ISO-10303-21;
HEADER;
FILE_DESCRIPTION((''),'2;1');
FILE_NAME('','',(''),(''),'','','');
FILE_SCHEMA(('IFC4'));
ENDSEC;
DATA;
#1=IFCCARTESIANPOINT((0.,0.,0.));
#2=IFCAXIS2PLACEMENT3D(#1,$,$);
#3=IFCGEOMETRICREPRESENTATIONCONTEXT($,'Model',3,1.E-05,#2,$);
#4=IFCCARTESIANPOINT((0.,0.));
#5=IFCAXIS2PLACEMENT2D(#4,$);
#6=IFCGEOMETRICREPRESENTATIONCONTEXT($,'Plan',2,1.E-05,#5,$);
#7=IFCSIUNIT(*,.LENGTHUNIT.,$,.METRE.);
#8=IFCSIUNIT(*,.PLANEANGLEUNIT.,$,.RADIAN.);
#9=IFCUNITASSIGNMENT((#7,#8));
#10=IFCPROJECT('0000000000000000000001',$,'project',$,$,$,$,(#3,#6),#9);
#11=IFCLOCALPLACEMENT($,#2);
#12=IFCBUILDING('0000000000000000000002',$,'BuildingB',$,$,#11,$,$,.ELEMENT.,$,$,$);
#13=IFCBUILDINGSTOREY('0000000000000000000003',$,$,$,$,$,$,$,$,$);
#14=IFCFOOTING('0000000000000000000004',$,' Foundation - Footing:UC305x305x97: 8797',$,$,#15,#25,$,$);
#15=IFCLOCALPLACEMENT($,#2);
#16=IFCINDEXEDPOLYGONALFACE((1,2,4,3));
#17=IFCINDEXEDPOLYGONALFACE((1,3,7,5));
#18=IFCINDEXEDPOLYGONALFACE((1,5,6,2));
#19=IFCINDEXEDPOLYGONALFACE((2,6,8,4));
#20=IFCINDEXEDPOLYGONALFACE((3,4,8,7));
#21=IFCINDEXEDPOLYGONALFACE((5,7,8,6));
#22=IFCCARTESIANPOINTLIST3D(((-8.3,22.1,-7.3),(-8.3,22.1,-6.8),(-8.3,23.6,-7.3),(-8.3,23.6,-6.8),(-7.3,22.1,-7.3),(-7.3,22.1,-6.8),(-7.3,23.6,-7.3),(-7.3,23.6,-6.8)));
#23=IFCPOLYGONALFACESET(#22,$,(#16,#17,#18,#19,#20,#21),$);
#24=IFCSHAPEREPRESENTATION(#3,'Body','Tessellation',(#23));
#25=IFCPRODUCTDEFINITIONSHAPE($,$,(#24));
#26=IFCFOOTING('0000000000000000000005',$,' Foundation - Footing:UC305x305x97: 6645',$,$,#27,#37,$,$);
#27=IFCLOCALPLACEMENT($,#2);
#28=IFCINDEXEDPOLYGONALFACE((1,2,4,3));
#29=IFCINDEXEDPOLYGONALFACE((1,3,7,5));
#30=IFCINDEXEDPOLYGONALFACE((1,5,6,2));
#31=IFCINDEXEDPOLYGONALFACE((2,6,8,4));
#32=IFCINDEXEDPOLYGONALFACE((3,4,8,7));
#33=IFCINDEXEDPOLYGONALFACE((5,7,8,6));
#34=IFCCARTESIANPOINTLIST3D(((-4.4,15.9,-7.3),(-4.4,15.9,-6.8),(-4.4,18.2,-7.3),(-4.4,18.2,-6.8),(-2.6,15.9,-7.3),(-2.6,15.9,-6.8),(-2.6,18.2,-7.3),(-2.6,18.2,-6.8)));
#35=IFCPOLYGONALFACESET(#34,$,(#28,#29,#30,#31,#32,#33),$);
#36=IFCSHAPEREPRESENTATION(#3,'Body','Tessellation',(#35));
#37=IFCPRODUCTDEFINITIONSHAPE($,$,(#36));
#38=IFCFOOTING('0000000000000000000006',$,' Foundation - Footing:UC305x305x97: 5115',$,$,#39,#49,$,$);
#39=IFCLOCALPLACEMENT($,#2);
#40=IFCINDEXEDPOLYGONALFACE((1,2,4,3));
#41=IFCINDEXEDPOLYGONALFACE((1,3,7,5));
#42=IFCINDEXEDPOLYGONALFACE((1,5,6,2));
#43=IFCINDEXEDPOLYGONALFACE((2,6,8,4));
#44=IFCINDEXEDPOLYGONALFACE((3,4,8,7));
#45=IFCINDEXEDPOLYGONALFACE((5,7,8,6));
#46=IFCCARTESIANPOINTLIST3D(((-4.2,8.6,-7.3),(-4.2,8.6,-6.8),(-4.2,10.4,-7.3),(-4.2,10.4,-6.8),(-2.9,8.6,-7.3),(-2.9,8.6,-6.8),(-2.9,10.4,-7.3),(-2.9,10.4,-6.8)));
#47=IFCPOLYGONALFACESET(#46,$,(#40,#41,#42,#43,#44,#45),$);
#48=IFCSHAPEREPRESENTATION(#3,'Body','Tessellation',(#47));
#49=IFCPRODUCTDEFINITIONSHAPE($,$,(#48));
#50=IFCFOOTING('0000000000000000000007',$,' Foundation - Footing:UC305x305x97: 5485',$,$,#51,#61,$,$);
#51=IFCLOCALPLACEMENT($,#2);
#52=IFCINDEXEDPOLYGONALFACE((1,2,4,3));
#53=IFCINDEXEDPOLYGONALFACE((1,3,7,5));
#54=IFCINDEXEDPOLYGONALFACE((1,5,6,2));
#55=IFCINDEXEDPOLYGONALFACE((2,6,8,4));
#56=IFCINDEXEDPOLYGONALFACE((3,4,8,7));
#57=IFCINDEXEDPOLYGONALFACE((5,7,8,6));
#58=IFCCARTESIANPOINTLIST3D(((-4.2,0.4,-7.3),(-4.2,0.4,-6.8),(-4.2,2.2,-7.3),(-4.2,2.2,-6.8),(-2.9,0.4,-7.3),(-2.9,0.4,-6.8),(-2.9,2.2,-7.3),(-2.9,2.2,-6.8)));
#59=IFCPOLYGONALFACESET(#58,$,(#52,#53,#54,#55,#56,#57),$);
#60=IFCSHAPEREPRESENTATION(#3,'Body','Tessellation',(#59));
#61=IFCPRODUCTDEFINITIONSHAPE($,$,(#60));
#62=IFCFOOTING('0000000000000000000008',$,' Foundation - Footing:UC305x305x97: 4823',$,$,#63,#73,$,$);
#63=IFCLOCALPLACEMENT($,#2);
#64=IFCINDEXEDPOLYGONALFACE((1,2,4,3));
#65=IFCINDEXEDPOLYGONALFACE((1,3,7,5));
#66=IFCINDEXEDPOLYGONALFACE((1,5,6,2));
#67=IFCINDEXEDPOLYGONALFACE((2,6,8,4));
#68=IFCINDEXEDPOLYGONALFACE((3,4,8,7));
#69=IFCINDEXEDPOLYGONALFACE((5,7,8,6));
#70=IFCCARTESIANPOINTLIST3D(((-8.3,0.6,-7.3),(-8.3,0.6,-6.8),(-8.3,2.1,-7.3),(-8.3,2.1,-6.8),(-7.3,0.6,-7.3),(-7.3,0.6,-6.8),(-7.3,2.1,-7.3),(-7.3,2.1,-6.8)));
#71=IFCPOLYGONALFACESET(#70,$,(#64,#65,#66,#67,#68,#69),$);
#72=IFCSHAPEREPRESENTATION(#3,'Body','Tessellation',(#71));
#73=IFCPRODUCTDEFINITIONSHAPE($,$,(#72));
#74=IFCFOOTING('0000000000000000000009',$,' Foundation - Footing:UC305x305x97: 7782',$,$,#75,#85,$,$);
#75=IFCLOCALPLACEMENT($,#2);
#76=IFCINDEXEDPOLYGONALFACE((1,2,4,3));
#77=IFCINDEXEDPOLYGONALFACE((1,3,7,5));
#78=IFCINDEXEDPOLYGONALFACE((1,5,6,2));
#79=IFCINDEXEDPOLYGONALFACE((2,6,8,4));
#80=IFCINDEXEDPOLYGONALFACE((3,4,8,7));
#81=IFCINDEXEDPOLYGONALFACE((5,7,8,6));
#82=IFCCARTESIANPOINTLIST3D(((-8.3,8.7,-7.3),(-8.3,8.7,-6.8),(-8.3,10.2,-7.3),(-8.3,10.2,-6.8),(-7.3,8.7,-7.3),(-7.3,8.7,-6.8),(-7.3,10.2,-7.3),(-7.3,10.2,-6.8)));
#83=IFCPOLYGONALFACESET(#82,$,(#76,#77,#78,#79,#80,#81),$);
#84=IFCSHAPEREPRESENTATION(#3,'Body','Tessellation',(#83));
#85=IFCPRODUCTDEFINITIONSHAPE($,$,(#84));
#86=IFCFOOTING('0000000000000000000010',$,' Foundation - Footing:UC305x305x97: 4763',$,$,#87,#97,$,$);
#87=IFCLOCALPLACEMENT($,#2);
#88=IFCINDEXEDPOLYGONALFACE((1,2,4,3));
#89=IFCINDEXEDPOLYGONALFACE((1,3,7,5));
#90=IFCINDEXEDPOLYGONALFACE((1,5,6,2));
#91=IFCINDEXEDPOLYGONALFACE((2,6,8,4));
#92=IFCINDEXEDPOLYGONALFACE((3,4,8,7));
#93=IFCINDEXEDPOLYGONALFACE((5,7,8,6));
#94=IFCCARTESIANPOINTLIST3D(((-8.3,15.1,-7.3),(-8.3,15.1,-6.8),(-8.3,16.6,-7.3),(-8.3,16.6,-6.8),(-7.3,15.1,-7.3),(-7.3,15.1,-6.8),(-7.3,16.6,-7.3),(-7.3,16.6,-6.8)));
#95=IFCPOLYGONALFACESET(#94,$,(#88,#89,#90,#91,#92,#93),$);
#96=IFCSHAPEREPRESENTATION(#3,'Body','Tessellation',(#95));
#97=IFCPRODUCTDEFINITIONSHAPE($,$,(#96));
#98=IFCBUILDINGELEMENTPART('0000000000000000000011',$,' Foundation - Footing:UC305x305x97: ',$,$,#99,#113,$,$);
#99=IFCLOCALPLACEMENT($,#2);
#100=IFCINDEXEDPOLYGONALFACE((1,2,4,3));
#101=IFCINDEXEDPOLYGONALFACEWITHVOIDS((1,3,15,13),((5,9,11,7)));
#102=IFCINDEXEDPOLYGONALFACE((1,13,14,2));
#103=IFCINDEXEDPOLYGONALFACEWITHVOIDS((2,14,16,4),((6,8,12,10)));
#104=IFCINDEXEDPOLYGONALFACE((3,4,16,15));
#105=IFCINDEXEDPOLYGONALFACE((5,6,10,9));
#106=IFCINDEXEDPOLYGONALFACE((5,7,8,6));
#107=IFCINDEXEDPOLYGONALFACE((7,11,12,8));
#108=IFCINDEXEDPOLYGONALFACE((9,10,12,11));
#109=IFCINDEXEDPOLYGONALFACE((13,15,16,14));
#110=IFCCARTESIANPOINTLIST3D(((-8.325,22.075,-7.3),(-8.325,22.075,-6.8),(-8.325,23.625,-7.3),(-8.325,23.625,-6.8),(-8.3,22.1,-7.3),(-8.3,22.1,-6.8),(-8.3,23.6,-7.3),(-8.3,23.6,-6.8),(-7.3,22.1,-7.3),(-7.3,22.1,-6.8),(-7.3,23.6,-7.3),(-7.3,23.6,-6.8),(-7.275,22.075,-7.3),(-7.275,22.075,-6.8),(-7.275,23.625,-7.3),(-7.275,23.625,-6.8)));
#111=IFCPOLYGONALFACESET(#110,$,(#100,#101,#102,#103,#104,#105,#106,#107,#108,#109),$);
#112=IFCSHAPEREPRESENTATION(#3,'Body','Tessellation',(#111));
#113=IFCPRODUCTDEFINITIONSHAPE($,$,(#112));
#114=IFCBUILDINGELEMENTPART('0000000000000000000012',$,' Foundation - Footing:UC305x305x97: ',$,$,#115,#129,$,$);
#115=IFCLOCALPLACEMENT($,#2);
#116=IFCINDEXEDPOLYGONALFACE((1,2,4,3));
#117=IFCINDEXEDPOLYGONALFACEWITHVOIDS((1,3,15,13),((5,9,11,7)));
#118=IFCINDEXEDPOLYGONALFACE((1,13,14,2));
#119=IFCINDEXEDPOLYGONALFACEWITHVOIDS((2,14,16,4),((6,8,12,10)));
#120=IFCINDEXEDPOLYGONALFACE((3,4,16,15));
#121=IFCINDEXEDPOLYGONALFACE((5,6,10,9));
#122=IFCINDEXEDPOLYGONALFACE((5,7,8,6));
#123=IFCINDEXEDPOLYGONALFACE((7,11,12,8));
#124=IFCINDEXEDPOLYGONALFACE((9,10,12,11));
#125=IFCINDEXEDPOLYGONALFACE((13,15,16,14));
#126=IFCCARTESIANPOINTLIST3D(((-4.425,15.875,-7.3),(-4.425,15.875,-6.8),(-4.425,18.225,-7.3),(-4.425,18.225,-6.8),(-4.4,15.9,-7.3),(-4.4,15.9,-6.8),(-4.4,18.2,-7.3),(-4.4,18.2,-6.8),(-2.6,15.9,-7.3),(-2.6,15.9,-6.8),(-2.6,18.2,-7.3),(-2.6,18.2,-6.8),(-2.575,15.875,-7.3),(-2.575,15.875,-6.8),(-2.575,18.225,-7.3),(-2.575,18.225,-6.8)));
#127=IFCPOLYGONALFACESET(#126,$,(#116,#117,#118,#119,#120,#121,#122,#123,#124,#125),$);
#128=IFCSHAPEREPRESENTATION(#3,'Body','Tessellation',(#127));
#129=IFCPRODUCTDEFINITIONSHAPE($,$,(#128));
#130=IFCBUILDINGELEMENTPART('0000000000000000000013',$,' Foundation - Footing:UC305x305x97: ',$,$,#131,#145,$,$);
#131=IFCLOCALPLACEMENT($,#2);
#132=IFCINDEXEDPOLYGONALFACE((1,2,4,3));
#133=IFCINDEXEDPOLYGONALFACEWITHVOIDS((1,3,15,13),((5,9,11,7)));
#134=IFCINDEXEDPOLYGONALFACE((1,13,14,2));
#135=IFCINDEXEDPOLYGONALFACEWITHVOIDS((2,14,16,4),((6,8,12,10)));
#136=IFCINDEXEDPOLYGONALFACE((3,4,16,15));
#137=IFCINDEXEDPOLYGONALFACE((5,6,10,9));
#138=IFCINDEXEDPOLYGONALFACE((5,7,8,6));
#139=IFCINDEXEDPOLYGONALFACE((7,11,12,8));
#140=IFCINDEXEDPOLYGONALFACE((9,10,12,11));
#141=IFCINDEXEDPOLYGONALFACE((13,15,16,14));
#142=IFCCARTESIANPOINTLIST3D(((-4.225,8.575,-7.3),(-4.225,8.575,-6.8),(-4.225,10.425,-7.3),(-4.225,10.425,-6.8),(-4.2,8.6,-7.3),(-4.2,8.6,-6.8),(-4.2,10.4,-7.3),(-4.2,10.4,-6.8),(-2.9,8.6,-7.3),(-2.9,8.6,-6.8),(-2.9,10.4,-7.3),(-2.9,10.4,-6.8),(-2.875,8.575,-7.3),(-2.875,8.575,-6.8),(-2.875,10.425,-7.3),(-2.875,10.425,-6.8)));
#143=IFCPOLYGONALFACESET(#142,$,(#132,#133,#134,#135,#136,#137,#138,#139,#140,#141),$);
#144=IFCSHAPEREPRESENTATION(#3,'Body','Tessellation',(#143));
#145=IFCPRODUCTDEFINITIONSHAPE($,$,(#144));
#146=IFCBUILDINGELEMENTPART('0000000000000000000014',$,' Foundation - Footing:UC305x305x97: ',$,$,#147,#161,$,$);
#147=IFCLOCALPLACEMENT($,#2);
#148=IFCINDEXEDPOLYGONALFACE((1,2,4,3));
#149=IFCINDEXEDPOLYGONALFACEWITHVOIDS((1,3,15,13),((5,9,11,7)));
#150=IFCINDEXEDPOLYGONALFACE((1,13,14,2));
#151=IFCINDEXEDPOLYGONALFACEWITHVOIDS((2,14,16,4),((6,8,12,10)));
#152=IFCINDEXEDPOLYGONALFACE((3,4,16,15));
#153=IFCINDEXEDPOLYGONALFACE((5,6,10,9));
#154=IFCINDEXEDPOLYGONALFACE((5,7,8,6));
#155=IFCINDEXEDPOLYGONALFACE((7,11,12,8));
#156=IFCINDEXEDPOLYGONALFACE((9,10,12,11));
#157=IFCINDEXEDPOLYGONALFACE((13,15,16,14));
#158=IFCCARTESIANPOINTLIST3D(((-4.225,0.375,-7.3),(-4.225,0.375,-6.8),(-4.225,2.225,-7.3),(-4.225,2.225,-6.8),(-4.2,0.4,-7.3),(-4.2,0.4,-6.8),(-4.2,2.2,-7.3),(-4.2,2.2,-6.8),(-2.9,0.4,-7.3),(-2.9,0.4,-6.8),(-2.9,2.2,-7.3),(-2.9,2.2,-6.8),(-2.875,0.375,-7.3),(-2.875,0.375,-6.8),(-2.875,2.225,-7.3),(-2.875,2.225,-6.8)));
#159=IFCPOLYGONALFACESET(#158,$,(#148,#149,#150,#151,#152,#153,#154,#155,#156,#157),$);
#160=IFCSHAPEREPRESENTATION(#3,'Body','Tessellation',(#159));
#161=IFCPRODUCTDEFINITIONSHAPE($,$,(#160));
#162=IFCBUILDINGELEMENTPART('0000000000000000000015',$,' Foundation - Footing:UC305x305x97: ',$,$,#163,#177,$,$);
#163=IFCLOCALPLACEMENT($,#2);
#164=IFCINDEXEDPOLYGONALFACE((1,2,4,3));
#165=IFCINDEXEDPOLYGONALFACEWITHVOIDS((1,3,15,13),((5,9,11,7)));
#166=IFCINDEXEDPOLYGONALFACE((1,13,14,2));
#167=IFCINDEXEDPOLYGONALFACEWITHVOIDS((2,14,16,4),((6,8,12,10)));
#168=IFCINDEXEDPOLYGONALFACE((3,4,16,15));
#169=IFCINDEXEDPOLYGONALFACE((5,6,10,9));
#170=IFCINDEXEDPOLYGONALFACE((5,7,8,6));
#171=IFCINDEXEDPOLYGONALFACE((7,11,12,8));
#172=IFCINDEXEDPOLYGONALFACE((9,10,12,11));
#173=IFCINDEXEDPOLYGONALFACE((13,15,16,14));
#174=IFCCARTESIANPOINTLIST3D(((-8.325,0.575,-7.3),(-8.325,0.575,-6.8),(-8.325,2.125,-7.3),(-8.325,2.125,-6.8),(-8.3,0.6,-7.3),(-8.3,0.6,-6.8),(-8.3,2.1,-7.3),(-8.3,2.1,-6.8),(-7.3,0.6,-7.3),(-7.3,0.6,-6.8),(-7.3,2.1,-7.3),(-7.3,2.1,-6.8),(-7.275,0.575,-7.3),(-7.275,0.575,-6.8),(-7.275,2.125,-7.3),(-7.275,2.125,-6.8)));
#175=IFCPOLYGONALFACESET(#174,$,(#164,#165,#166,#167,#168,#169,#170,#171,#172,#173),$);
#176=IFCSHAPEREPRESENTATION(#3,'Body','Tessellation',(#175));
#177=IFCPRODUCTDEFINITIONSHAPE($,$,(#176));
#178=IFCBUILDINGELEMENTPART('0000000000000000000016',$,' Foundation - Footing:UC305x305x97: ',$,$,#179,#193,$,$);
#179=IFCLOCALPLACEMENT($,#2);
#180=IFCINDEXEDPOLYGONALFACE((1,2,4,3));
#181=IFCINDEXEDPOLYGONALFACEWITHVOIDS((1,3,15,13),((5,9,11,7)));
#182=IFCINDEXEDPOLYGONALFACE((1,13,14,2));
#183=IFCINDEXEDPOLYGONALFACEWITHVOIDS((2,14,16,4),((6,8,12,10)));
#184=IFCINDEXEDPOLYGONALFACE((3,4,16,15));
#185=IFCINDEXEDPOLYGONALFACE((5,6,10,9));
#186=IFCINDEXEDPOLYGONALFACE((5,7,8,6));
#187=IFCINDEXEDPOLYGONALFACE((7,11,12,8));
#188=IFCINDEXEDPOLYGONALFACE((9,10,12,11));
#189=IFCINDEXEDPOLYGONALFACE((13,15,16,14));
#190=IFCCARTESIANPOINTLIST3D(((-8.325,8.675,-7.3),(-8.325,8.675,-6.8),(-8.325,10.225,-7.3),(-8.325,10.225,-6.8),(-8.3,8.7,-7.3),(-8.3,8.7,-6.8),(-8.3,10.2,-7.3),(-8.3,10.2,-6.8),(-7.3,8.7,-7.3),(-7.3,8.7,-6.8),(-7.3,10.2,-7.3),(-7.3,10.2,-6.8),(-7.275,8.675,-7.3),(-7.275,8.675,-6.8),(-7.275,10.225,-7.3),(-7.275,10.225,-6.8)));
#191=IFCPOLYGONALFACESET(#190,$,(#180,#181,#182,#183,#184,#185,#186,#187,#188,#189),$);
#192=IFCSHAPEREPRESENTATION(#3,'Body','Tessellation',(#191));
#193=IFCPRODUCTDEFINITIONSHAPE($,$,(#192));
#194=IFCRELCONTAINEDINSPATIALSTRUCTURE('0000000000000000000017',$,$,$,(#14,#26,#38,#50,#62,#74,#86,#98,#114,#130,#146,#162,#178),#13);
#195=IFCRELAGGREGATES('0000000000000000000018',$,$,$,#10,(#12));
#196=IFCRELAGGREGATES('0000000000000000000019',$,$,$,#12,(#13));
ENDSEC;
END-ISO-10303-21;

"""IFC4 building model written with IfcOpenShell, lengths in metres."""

from ifc_helpers import new_model, si_unit, origin, origin_2d, place, context, project, spatial, polyline, outline, extrude, element, save


model = new_model("IFC4")

# Units and contexts
model_context = context("Model", 3, precision=1e-05, world=origin())
plan_context = context("Plan", 2, precision=1e-05, world=origin_2d())
ifc_project = project(units=[si_unit("LENGTHUNIT", "METRE"), si_unit("PLANEANGLEUNIT", "RADIAN")], contexts=[model_context, plan_context])

# Building, storey
building_placement = place(None, origin())
building = spatial("IfcBuilding", under=ifc_project, at=building_placement, Name="BuildingB", CompositionType="ELEMENT")
storey = spatial("IfcBuildingStorey", under=building)

# Footings
element("IfcFooting", 1, inside=storey, Name=" Foundation - Footing:UC305x305x97: 8797", context=model_context, shape_type="SweptSolid", body=[
    extrude(outline(polyline([(-7.3, 23.6, -7.3), (-8.3, 23.6, -7.3), (-8.3, 22.1, -7.3), (-7.3, 22.1, -7.3), (-7.3, 23.6, -7.3)])), None, (0.0, 0.0, 1.0), 0.5),
])
element("IfcFooting", 2, inside=storey, Name=" Foundation - Footing:UC305x305x97: 6645", context=model_context, shape_type="SweptSolid", body=[
    extrude(outline(polyline([(-2.6, 18.2, -7.3), (-4.4, 18.2, -7.3), (-4.4, 15.9, -7.3), (-2.6, 15.9, -7.3), (-2.6, 18.2, -7.3)])), None, (0.0, 0.0, 1.0), 0.5),
])
element("IfcFooting", 3, inside=storey, Name=" Foundation - Footing:UC305x305x97: 5115", context=model_context, shape_type="SweptSolid", body=[
    extrude(outline(polyline([(-2.9, 10.4, -7.3), (-4.2, 10.4, -7.3), (-4.2, 8.6, -7.3), (-2.9, 8.6, -7.3), (-2.9, 10.4, -7.3)])), None, (0.0, 0.0, 1.0), 0.5),
])
element("IfcFooting", 4, inside=storey, Name=" Foundation - Footing:UC305x305x97: 5485", context=model_context, shape_type="SweptSolid", body=[
    extrude(outline(polyline([(-2.9, 2.2, -7.3), (-4.2, 2.2, -7.3), (-4.2, 0.4, -7.3), (-2.9, 0.4, -7.3), (-2.9, 2.2, -7.3)])), None, (0.0, 0.0, 1.0), 0.5),
])
element("IfcFooting", 5, inside=storey, Name=" Foundation - Footing:UC305x305x97: 4823", context=model_context, shape_type="SweptSolid", body=[
    extrude(outline(polyline([(-7.3, 2.1, -7.3), (-8.3, 2.1, -7.3), (-8.3, 0.6, -7.3), (-7.3, 0.6, -7.3), (-7.3, 2.1, -7.3)])), None, (0.0, 0.0, 1.0), 0.5),
])
element("IfcFooting", 6, inside=storey, Name=" Foundation - Footing:UC305x305x97: 7782", context=model_context, shape_type="SweptSolid", body=[
    extrude(outline(polyline([(-7.3, 10.2, -7.3), (-8.3, 10.2, -7.3), (-8.3, 8.7, -7.3), (-7.3, 8.7, -7.3), (-7.3, 10.2, -7.3)])), None, (0.0, 0.0, 1.0), 0.5),
])
element("IfcFooting", 7, inside=storey, Name=" Foundation - Footing:UC305x305x97: 4763", context=model_context, shape_type="SweptSolid", body=[
    extrude(outline(polyline([(-7.3, 16.6, -7.3), (-8.3, 16.6, -7.3), (-8.3, 15.1, -7.3), (-7.3, 15.1, -7.3), (-7.3, 16.6, -7.3)])), None, (0.0, 0.0, 1.0), 0.5),
])

# Building element parts, openings
building_element_part_1 = element("IfcBuildingElementPart", 8, inside=storey, Name=" Foundation - Footing:UC305x305x97: ", context=model_context, shape_type="SweptSolid", body=[
    extrude(outline(polyline([(-7.275, 23.625, -7.3), (-8.325, 23.625, -7.3), (-8.325, 22.075, -7.3), (-7.275, 22.075, -7.3), (-7.275, 23.625, -7.3)])), None, (0.0, 0.0, 1.0), 0.5),
])
element("IfcOpeningElement", 9, inside=storey, cuts=building_element_part_1, context=model_context, shape_type="SweptSolid", body=[
    extrude(outline(polyline([(-7.3, 23.6, -7.3), (-8.3, 23.6, -7.3), (-8.3, 22.1, -7.3), (-7.3, 22.1, -7.3), (-7.3, 23.6, -7.3)])), None, (0.0, 0.0, 1.0), 0.5),
])
building_element_part_2 = element("IfcBuildingElementPart", 10, inside=storey, Name=" Foundation - Footing:UC305x305x97: ", context=model_context, shape_type="SweptSolid", body=[
    extrude(outline(polyline([(-2.575, 18.225, -7.3), (-4.425, 18.225, -7.3), (-4.425, 15.875, -7.3), (-2.575, 15.875, -7.3), (-2.575, 18.225, -7.3)])), None, (0.0, 0.0, 1.0), 0.5),
])
element("IfcOpeningElement", 11, inside=storey, cuts=building_element_part_2, context=model_context, shape_type="SweptSolid", body=[
    extrude(outline(polyline([(-2.6, 18.2, -7.3), (-4.4, 18.2, -7.3), (-4.4, 15.9, -7.3), (-2.6, 15.9, -7.3), (-2.6, 18.2, -7.3)])), None, (0.0, 0.0, 1.0), 0.5),
])
building_element_part_3 = element("IfcBuildingElementPart", 12, inside=storey, Name=" Foundation - Footing:UC305x305x97: ", context=model_context, shape_type="SweptSolid", body=[
    extrude(outline(polyline([(-2.875, 10.425, -7.3), (-4.225, 10.425, -7.3), (-4.225, 8.575, -7.3), (-2.875, 8.575, -7.3), (-2.875, 10.425, -7.3)])), None, (0.0, 0.0, 1.0), 0.5),
])
element("IfcOpeningElement", 13, inside=storey, cuts=building_element_part_3, context=model_context, shape_type="SweptSolid", body=[
    extrude(outline(polyline([(-2.9, 10.4, -7.3), (-4.2, 10.4, -7.3), (-4.2, 8.6, -7.3), (-2.9, 8.6, -7.3), (-2.9, 10.4, -7.3)])), None, (0.0, 0.0, 1.0), 0.5),
])
building_element_part_4 = element("IfcBuildingElementPart", 14, inside=storey, Name=" Foundation - Footing:UC305x305x97: ", context=model_context, shape_type="SweptSolid", body=[
    extrude(outline(polyline([(-2.875, 2.225, -7.3), (-4.225, 2.225, -7.3), (-4.225, 0.375, -7.3), (-2.875, 0.375, -7.3), (-2.875, 2.225, -7.3)])), None, (0.0, 0.0, 1.0), 0.5),
])
element("IfcOpeningElement", 15, inside=storey, cuts=building_element_part_4, context=model_context, shape_type="SweptSolid", body=[
    extrude(outline(polyline([(-2.9, 2.2, -7.3), (-4.2, 2.2, -7.3), (-4.2, 0.4, -7.3), (-2.9, 0.4, -7.3), (-2.9, 2.2, -7.3)])), None, (0.0, 0.0, 1.0), 0.5),
])
building_element_part_5 = element("IfcBuildingElementPart", 16, inside=storey, Name=" Foundation - Footing:UC305x305x97: ", context=model_context, shape_type="SweptSolid", body=[
    extrude(outline(polyline([(-7.275, 2.125, -7.3), (-8.325, 2.125, -7.3), (-8.325, 0.575, -7.3), (-7.275, 0.575, -7.3), (-7.275, 2.125, -7.3)])), None, (0.0, 0.0, 1.0), 0.5),
])
element("IfcOpeningElement", 17, inside=storey, cuts=building_element_part_5, context=model_context, shape_type="SweptSolid", body=[
    extrude(outline(polyline([(-7.3, 2.1, -7.3), (-8.3, 2.1, -7.3), (-8.3, 0.6, -7.3), (-7.3, 0.6, -7.3), (-7.3, 2.1, -7.3)])), None, (0.0, 0.0, 1.0), 0.5),
])
building_element_part_6 = element("IfcBuildingElementPart", 18, inside=storey, Name=" Foundation - Footing:UC305x305x97: ", context=model_context, shape_type="SweptSolid", body=[
    extrude(outline(polyline([(-7.275, 10.225, -7.3), (-8.325, 10.225, -7.3), (-8.325, 8.675, -7.3), (-7.275, 8.675, -7.3), (-7.275, 10.225, -7.3)])), None, (0.0, 0.0, 1.0), 0.5),
])
element("IfcOpeningElement", 19, inside=storey, cuts=building_element_part_6, context=model_context, shape_type="SweptSolid", body=[
    extrude(outline(polyline([(-7.3, 10.2, -7.3), (-8.3, 10.2, -7.3), (-8.3, 8.7, -7.3), (-7.3, 8.7, -7.3), (-7.3, 10.2, -7.3)])), None, (0.0, 0.0, 1.0), 0.5),
])

save(model, "model.ifc")
